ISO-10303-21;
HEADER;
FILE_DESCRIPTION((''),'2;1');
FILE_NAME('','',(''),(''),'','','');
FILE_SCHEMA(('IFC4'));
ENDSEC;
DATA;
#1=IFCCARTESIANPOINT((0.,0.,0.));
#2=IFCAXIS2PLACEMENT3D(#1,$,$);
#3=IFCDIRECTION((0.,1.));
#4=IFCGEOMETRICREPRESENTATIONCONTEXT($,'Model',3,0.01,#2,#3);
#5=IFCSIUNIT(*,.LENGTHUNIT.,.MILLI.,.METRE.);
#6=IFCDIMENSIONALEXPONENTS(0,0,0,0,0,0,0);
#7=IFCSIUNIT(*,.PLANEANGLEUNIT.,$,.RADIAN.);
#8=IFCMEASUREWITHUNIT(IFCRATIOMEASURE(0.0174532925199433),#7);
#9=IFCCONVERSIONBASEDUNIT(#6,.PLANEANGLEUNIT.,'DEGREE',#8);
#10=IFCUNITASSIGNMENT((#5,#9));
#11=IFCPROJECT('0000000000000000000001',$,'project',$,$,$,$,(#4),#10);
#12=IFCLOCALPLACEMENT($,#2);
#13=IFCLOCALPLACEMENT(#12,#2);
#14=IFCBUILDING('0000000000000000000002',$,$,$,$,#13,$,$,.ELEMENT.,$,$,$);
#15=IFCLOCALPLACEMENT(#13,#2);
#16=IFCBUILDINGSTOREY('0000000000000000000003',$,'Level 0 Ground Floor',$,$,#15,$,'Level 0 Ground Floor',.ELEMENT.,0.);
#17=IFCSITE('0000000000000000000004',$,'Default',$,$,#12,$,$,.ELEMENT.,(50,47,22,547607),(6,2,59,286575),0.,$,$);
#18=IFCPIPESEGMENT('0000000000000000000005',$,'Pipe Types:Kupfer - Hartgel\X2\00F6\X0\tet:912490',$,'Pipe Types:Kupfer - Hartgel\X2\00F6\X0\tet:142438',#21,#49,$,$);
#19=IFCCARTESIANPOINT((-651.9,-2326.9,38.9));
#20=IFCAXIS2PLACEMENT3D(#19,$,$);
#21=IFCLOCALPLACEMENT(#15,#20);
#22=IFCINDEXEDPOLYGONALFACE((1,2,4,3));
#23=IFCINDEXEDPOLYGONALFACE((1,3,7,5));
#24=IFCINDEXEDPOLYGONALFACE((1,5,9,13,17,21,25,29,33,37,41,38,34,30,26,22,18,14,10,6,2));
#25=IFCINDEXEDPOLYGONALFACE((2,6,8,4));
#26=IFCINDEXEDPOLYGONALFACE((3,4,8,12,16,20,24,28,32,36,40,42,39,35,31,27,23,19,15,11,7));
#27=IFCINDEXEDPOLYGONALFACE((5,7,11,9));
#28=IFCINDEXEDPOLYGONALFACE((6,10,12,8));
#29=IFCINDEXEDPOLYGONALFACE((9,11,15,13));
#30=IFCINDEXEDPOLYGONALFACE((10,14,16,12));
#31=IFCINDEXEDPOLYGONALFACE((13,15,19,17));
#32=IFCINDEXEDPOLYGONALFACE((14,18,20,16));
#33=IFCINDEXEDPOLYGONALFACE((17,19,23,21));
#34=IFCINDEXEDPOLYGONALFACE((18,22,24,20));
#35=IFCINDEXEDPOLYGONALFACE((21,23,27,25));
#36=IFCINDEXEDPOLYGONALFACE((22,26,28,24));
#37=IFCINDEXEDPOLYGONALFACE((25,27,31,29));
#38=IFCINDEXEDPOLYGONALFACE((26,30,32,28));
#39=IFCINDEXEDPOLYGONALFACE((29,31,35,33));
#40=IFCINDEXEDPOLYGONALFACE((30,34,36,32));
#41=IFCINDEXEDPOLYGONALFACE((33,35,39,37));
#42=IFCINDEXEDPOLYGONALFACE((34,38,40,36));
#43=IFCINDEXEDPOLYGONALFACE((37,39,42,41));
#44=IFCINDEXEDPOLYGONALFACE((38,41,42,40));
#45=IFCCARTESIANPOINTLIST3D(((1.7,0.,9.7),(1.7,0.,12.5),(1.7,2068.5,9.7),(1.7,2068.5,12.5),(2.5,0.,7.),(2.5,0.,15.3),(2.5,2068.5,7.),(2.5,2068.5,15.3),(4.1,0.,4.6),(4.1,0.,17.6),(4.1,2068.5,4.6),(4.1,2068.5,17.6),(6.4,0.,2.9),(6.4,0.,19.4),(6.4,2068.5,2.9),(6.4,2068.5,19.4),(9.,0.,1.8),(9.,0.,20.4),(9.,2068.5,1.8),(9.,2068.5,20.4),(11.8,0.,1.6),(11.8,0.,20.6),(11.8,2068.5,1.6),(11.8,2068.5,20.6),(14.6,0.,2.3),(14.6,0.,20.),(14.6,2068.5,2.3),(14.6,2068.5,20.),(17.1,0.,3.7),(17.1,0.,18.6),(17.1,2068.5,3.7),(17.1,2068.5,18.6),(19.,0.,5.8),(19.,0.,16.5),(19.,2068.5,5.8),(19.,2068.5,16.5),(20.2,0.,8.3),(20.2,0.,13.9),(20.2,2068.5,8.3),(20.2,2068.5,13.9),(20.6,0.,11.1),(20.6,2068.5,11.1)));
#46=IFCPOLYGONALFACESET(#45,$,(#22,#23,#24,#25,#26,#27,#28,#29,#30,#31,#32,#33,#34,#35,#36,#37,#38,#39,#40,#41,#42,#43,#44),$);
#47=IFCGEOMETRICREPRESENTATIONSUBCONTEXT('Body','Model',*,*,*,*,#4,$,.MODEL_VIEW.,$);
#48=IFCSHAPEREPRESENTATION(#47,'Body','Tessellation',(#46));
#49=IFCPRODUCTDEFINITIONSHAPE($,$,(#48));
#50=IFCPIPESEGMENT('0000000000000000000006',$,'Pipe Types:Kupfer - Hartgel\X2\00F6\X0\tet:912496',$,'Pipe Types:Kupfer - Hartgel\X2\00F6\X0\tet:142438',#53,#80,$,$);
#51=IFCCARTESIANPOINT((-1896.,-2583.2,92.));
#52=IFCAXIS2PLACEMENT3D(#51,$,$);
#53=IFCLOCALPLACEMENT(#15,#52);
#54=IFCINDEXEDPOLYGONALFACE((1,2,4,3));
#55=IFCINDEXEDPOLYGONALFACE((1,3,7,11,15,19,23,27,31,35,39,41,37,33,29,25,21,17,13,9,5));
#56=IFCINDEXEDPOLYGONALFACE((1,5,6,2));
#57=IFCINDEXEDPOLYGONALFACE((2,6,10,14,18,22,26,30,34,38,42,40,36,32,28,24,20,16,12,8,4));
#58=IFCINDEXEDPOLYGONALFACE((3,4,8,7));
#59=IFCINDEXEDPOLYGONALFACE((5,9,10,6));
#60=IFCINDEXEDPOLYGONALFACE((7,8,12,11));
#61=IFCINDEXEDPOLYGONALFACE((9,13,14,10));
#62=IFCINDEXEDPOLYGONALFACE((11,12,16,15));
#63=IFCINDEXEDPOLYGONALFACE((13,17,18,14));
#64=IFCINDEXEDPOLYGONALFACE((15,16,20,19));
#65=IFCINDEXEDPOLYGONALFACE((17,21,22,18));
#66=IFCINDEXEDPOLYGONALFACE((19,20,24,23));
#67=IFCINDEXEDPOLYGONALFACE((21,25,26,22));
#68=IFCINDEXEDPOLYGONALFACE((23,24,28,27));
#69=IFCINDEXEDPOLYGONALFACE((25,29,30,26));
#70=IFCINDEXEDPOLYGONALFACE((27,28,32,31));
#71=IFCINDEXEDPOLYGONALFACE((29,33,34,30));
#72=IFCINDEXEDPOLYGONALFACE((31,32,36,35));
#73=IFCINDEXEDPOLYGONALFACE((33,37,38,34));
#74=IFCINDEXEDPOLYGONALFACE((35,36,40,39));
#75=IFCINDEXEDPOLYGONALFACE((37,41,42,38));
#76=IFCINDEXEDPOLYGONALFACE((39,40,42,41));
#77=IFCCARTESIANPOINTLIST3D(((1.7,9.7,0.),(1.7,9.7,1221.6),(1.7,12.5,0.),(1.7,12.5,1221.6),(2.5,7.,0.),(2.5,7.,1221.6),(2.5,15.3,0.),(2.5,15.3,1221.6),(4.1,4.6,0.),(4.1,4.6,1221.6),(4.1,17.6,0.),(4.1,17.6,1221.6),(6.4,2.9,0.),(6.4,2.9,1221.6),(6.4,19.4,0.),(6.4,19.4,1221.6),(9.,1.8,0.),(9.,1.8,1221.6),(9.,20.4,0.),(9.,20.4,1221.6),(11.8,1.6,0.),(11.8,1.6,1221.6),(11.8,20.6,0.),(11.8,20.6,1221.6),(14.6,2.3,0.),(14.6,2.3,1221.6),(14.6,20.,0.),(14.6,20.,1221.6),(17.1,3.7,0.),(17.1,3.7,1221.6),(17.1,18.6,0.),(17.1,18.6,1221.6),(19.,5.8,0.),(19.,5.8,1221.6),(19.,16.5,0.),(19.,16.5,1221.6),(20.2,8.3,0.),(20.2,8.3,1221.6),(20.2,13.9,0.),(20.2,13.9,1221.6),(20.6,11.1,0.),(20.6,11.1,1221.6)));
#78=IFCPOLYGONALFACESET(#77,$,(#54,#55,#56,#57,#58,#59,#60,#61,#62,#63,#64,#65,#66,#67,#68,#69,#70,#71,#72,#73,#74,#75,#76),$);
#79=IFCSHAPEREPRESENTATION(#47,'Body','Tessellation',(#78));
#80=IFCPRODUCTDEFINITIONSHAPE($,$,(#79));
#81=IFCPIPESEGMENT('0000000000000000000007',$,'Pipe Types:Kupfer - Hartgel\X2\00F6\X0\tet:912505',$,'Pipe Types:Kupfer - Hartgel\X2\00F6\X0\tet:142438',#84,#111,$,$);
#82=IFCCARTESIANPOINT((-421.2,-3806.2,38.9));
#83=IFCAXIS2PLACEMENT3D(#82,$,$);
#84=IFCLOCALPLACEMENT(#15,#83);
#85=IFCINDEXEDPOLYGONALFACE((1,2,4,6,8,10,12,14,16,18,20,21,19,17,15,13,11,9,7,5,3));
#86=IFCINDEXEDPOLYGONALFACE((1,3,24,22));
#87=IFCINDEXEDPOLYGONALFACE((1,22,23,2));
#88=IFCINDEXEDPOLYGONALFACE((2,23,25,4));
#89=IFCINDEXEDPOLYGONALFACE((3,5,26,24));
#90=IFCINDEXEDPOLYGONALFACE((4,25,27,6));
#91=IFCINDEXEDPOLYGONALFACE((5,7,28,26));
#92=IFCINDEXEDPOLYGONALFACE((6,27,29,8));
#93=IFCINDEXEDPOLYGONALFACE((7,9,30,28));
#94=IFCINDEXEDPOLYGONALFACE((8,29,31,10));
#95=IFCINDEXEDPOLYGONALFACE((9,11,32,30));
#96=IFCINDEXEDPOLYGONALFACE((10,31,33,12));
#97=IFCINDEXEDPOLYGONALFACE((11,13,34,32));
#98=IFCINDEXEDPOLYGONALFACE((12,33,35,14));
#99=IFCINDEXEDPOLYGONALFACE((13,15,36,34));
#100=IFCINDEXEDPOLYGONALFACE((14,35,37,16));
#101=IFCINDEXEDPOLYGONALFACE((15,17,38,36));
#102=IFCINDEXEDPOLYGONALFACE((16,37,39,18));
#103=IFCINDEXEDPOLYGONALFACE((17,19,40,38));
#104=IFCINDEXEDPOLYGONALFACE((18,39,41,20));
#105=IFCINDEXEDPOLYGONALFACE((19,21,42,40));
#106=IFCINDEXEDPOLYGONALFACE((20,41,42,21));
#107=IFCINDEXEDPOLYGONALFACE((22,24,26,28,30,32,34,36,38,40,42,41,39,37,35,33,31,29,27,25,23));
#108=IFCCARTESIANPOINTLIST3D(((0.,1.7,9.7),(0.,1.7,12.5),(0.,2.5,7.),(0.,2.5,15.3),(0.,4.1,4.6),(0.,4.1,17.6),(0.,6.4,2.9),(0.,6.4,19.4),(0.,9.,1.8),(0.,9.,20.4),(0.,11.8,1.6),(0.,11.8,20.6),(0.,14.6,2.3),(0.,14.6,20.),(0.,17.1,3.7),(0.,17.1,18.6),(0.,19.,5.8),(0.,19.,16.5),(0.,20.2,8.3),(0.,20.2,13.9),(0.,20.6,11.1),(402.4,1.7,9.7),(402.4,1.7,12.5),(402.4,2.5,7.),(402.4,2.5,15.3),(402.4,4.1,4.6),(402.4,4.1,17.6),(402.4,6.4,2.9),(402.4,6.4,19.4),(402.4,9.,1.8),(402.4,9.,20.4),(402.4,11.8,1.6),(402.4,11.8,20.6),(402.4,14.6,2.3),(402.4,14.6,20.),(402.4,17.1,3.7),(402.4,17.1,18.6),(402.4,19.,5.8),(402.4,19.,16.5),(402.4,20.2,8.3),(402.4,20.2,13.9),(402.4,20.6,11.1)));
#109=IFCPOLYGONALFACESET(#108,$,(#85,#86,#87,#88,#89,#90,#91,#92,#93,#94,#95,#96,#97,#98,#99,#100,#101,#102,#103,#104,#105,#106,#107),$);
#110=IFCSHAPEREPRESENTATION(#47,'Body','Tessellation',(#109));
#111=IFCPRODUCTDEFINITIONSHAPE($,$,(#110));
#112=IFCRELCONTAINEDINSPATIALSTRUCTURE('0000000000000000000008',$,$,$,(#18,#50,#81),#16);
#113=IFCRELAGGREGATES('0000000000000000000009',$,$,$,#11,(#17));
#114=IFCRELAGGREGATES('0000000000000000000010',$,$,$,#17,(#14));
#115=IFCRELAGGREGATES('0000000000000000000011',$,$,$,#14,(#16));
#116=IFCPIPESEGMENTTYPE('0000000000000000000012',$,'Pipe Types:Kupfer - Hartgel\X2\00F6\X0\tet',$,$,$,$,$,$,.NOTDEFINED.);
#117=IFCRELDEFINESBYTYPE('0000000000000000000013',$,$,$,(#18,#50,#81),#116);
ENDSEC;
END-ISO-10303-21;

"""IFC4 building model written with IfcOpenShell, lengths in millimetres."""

from ifc_helpers import new_model, entity, si_unit, converted_unit, direction, frame, frame_2d, origin, origin_2d_with_axis, place, context, subcontext, project, spatial, circle, extrude, type_object, element, save


model = new_model("IFC4")

# Units and contexts
model_context = context("Model", 3, precision=0.01, world=origin(), true_north=direction((0.0, 1.0)))
body_context = subcontext(model_context, "Body", "Model", "MODEL_VIEW")
ifc_project = project(units=[si_unit("LENGTHUNIT", "METRE", prefix="MILLI"), converted_unit("PLANEANGLEUNIT", "DEGREE", entity("IfcRatioMeasure", 0.0174532925199433), si_unit("PLANEANGLEUNIT", "RADIAN"), dimensions=[0, 0, 0, 0, 0, 0, 0])], contexts=[model_context])

# Site, building, storey
site_placement = place(None, origin())
site = spatial("IfcSite", under=ifc_project, at=site_placement, Name="Default", CompositionType="ELEMENT", RefLatitude=(50, 47, 22, 547607), RefLongitude=(6, 2, 59, 286575), RefElevation=0.0)
building_placement = place(site_placement, origin())
building = spatial("IfcBuilding", under=site, at=building_placement, CompositionType="ELEMENT")
storey_placement = place(building_placement, origin())
storey = spatial("IfcBuildingStorey", under=building, at=storey_placement, Name="Level 0 Ground Floor", LongName="Level 0 Ground Floor", CompositionType="ELEMENT", Elevation=0.0)

# Pipe segments
pipe_segment_type = type_object("IfcPipeSegmentType", Name="Pipe Types:Kupfer - Hartgelötet", PredefinedType="NOTDEFINED")
pipe_segment_1_placement = place(storey_placement, frame((-651.9, -2326.9, 38.9)))
element("IfcPipeSegment", 1, at=pipe_segment_1_placement, inside=storey, type_object=pipe_segment_type, Name="Pipe Types:Kupfer - Hartgelötet:912490", ObjectType="Pipe Types:Kupfer - Hartgelötet:142438", context=body_context, shape_type="SweptSolid", body=[
    extrude(circle(Radius=9.5, at=frame_2d((0.0, 0.0), x_axis=(1.0, 0.0))), frame((11.1, 0.0, 11.1), z_axis=(0.0, 1.0, 0.0), x_axis=(1.0, 0.0, 0.0)), (0.0, 0.0, 1.0), 2068.5),
])
pipe_segment_2_placement = place(storey_placement, frame((-1896.0, -2583.2, 92.0)))
element("IfcPipeSegment", 2, at=pipe_segment_2_placement, inside=storey, type_object=pipe_segment_type, Name="Pipe Types:Kupfer - Hartgelötet:912496", ObjectType="Pipe Types:Kupfer - Hartgelötet:142438", context=body_context, shape_type="SweptSolid", body=[
    extrude(circle(Radius=9.5, at=origin_2d_with_axis()), frame((11.1, 11.1, 0.0)), (0.0, 0.0, 1.0), 1221.6),
])
pipe_segment_3_placement = place(storey_placement, frame((-421.2, -3806.2, 38.9)))
element("IfcPipeSegment", 3, at=pipe_segment_3_placement, inside=storey, type_object=pipe_segment_type, Name="Pipe Types:Kupfer - Hartgelötet:912505", ObjectType="Pipe Types:Kupfer - Hartgelötet:142438", context=body_context, shape_type="SweptSolid", body=[
    extrude(circle(Radius=9.5, at=frame_2d((0.0, 0.0), x_axis=(1.0, 0.0))), frame((0.0, 11.1, 11.1), z_axis=(1.0, 0.0, 0.0), x_axis=(0.0, 1.0, 0.0)), (0.0, 0.0, 1.0), 402.4),
])

save(model, "model.ifc")
